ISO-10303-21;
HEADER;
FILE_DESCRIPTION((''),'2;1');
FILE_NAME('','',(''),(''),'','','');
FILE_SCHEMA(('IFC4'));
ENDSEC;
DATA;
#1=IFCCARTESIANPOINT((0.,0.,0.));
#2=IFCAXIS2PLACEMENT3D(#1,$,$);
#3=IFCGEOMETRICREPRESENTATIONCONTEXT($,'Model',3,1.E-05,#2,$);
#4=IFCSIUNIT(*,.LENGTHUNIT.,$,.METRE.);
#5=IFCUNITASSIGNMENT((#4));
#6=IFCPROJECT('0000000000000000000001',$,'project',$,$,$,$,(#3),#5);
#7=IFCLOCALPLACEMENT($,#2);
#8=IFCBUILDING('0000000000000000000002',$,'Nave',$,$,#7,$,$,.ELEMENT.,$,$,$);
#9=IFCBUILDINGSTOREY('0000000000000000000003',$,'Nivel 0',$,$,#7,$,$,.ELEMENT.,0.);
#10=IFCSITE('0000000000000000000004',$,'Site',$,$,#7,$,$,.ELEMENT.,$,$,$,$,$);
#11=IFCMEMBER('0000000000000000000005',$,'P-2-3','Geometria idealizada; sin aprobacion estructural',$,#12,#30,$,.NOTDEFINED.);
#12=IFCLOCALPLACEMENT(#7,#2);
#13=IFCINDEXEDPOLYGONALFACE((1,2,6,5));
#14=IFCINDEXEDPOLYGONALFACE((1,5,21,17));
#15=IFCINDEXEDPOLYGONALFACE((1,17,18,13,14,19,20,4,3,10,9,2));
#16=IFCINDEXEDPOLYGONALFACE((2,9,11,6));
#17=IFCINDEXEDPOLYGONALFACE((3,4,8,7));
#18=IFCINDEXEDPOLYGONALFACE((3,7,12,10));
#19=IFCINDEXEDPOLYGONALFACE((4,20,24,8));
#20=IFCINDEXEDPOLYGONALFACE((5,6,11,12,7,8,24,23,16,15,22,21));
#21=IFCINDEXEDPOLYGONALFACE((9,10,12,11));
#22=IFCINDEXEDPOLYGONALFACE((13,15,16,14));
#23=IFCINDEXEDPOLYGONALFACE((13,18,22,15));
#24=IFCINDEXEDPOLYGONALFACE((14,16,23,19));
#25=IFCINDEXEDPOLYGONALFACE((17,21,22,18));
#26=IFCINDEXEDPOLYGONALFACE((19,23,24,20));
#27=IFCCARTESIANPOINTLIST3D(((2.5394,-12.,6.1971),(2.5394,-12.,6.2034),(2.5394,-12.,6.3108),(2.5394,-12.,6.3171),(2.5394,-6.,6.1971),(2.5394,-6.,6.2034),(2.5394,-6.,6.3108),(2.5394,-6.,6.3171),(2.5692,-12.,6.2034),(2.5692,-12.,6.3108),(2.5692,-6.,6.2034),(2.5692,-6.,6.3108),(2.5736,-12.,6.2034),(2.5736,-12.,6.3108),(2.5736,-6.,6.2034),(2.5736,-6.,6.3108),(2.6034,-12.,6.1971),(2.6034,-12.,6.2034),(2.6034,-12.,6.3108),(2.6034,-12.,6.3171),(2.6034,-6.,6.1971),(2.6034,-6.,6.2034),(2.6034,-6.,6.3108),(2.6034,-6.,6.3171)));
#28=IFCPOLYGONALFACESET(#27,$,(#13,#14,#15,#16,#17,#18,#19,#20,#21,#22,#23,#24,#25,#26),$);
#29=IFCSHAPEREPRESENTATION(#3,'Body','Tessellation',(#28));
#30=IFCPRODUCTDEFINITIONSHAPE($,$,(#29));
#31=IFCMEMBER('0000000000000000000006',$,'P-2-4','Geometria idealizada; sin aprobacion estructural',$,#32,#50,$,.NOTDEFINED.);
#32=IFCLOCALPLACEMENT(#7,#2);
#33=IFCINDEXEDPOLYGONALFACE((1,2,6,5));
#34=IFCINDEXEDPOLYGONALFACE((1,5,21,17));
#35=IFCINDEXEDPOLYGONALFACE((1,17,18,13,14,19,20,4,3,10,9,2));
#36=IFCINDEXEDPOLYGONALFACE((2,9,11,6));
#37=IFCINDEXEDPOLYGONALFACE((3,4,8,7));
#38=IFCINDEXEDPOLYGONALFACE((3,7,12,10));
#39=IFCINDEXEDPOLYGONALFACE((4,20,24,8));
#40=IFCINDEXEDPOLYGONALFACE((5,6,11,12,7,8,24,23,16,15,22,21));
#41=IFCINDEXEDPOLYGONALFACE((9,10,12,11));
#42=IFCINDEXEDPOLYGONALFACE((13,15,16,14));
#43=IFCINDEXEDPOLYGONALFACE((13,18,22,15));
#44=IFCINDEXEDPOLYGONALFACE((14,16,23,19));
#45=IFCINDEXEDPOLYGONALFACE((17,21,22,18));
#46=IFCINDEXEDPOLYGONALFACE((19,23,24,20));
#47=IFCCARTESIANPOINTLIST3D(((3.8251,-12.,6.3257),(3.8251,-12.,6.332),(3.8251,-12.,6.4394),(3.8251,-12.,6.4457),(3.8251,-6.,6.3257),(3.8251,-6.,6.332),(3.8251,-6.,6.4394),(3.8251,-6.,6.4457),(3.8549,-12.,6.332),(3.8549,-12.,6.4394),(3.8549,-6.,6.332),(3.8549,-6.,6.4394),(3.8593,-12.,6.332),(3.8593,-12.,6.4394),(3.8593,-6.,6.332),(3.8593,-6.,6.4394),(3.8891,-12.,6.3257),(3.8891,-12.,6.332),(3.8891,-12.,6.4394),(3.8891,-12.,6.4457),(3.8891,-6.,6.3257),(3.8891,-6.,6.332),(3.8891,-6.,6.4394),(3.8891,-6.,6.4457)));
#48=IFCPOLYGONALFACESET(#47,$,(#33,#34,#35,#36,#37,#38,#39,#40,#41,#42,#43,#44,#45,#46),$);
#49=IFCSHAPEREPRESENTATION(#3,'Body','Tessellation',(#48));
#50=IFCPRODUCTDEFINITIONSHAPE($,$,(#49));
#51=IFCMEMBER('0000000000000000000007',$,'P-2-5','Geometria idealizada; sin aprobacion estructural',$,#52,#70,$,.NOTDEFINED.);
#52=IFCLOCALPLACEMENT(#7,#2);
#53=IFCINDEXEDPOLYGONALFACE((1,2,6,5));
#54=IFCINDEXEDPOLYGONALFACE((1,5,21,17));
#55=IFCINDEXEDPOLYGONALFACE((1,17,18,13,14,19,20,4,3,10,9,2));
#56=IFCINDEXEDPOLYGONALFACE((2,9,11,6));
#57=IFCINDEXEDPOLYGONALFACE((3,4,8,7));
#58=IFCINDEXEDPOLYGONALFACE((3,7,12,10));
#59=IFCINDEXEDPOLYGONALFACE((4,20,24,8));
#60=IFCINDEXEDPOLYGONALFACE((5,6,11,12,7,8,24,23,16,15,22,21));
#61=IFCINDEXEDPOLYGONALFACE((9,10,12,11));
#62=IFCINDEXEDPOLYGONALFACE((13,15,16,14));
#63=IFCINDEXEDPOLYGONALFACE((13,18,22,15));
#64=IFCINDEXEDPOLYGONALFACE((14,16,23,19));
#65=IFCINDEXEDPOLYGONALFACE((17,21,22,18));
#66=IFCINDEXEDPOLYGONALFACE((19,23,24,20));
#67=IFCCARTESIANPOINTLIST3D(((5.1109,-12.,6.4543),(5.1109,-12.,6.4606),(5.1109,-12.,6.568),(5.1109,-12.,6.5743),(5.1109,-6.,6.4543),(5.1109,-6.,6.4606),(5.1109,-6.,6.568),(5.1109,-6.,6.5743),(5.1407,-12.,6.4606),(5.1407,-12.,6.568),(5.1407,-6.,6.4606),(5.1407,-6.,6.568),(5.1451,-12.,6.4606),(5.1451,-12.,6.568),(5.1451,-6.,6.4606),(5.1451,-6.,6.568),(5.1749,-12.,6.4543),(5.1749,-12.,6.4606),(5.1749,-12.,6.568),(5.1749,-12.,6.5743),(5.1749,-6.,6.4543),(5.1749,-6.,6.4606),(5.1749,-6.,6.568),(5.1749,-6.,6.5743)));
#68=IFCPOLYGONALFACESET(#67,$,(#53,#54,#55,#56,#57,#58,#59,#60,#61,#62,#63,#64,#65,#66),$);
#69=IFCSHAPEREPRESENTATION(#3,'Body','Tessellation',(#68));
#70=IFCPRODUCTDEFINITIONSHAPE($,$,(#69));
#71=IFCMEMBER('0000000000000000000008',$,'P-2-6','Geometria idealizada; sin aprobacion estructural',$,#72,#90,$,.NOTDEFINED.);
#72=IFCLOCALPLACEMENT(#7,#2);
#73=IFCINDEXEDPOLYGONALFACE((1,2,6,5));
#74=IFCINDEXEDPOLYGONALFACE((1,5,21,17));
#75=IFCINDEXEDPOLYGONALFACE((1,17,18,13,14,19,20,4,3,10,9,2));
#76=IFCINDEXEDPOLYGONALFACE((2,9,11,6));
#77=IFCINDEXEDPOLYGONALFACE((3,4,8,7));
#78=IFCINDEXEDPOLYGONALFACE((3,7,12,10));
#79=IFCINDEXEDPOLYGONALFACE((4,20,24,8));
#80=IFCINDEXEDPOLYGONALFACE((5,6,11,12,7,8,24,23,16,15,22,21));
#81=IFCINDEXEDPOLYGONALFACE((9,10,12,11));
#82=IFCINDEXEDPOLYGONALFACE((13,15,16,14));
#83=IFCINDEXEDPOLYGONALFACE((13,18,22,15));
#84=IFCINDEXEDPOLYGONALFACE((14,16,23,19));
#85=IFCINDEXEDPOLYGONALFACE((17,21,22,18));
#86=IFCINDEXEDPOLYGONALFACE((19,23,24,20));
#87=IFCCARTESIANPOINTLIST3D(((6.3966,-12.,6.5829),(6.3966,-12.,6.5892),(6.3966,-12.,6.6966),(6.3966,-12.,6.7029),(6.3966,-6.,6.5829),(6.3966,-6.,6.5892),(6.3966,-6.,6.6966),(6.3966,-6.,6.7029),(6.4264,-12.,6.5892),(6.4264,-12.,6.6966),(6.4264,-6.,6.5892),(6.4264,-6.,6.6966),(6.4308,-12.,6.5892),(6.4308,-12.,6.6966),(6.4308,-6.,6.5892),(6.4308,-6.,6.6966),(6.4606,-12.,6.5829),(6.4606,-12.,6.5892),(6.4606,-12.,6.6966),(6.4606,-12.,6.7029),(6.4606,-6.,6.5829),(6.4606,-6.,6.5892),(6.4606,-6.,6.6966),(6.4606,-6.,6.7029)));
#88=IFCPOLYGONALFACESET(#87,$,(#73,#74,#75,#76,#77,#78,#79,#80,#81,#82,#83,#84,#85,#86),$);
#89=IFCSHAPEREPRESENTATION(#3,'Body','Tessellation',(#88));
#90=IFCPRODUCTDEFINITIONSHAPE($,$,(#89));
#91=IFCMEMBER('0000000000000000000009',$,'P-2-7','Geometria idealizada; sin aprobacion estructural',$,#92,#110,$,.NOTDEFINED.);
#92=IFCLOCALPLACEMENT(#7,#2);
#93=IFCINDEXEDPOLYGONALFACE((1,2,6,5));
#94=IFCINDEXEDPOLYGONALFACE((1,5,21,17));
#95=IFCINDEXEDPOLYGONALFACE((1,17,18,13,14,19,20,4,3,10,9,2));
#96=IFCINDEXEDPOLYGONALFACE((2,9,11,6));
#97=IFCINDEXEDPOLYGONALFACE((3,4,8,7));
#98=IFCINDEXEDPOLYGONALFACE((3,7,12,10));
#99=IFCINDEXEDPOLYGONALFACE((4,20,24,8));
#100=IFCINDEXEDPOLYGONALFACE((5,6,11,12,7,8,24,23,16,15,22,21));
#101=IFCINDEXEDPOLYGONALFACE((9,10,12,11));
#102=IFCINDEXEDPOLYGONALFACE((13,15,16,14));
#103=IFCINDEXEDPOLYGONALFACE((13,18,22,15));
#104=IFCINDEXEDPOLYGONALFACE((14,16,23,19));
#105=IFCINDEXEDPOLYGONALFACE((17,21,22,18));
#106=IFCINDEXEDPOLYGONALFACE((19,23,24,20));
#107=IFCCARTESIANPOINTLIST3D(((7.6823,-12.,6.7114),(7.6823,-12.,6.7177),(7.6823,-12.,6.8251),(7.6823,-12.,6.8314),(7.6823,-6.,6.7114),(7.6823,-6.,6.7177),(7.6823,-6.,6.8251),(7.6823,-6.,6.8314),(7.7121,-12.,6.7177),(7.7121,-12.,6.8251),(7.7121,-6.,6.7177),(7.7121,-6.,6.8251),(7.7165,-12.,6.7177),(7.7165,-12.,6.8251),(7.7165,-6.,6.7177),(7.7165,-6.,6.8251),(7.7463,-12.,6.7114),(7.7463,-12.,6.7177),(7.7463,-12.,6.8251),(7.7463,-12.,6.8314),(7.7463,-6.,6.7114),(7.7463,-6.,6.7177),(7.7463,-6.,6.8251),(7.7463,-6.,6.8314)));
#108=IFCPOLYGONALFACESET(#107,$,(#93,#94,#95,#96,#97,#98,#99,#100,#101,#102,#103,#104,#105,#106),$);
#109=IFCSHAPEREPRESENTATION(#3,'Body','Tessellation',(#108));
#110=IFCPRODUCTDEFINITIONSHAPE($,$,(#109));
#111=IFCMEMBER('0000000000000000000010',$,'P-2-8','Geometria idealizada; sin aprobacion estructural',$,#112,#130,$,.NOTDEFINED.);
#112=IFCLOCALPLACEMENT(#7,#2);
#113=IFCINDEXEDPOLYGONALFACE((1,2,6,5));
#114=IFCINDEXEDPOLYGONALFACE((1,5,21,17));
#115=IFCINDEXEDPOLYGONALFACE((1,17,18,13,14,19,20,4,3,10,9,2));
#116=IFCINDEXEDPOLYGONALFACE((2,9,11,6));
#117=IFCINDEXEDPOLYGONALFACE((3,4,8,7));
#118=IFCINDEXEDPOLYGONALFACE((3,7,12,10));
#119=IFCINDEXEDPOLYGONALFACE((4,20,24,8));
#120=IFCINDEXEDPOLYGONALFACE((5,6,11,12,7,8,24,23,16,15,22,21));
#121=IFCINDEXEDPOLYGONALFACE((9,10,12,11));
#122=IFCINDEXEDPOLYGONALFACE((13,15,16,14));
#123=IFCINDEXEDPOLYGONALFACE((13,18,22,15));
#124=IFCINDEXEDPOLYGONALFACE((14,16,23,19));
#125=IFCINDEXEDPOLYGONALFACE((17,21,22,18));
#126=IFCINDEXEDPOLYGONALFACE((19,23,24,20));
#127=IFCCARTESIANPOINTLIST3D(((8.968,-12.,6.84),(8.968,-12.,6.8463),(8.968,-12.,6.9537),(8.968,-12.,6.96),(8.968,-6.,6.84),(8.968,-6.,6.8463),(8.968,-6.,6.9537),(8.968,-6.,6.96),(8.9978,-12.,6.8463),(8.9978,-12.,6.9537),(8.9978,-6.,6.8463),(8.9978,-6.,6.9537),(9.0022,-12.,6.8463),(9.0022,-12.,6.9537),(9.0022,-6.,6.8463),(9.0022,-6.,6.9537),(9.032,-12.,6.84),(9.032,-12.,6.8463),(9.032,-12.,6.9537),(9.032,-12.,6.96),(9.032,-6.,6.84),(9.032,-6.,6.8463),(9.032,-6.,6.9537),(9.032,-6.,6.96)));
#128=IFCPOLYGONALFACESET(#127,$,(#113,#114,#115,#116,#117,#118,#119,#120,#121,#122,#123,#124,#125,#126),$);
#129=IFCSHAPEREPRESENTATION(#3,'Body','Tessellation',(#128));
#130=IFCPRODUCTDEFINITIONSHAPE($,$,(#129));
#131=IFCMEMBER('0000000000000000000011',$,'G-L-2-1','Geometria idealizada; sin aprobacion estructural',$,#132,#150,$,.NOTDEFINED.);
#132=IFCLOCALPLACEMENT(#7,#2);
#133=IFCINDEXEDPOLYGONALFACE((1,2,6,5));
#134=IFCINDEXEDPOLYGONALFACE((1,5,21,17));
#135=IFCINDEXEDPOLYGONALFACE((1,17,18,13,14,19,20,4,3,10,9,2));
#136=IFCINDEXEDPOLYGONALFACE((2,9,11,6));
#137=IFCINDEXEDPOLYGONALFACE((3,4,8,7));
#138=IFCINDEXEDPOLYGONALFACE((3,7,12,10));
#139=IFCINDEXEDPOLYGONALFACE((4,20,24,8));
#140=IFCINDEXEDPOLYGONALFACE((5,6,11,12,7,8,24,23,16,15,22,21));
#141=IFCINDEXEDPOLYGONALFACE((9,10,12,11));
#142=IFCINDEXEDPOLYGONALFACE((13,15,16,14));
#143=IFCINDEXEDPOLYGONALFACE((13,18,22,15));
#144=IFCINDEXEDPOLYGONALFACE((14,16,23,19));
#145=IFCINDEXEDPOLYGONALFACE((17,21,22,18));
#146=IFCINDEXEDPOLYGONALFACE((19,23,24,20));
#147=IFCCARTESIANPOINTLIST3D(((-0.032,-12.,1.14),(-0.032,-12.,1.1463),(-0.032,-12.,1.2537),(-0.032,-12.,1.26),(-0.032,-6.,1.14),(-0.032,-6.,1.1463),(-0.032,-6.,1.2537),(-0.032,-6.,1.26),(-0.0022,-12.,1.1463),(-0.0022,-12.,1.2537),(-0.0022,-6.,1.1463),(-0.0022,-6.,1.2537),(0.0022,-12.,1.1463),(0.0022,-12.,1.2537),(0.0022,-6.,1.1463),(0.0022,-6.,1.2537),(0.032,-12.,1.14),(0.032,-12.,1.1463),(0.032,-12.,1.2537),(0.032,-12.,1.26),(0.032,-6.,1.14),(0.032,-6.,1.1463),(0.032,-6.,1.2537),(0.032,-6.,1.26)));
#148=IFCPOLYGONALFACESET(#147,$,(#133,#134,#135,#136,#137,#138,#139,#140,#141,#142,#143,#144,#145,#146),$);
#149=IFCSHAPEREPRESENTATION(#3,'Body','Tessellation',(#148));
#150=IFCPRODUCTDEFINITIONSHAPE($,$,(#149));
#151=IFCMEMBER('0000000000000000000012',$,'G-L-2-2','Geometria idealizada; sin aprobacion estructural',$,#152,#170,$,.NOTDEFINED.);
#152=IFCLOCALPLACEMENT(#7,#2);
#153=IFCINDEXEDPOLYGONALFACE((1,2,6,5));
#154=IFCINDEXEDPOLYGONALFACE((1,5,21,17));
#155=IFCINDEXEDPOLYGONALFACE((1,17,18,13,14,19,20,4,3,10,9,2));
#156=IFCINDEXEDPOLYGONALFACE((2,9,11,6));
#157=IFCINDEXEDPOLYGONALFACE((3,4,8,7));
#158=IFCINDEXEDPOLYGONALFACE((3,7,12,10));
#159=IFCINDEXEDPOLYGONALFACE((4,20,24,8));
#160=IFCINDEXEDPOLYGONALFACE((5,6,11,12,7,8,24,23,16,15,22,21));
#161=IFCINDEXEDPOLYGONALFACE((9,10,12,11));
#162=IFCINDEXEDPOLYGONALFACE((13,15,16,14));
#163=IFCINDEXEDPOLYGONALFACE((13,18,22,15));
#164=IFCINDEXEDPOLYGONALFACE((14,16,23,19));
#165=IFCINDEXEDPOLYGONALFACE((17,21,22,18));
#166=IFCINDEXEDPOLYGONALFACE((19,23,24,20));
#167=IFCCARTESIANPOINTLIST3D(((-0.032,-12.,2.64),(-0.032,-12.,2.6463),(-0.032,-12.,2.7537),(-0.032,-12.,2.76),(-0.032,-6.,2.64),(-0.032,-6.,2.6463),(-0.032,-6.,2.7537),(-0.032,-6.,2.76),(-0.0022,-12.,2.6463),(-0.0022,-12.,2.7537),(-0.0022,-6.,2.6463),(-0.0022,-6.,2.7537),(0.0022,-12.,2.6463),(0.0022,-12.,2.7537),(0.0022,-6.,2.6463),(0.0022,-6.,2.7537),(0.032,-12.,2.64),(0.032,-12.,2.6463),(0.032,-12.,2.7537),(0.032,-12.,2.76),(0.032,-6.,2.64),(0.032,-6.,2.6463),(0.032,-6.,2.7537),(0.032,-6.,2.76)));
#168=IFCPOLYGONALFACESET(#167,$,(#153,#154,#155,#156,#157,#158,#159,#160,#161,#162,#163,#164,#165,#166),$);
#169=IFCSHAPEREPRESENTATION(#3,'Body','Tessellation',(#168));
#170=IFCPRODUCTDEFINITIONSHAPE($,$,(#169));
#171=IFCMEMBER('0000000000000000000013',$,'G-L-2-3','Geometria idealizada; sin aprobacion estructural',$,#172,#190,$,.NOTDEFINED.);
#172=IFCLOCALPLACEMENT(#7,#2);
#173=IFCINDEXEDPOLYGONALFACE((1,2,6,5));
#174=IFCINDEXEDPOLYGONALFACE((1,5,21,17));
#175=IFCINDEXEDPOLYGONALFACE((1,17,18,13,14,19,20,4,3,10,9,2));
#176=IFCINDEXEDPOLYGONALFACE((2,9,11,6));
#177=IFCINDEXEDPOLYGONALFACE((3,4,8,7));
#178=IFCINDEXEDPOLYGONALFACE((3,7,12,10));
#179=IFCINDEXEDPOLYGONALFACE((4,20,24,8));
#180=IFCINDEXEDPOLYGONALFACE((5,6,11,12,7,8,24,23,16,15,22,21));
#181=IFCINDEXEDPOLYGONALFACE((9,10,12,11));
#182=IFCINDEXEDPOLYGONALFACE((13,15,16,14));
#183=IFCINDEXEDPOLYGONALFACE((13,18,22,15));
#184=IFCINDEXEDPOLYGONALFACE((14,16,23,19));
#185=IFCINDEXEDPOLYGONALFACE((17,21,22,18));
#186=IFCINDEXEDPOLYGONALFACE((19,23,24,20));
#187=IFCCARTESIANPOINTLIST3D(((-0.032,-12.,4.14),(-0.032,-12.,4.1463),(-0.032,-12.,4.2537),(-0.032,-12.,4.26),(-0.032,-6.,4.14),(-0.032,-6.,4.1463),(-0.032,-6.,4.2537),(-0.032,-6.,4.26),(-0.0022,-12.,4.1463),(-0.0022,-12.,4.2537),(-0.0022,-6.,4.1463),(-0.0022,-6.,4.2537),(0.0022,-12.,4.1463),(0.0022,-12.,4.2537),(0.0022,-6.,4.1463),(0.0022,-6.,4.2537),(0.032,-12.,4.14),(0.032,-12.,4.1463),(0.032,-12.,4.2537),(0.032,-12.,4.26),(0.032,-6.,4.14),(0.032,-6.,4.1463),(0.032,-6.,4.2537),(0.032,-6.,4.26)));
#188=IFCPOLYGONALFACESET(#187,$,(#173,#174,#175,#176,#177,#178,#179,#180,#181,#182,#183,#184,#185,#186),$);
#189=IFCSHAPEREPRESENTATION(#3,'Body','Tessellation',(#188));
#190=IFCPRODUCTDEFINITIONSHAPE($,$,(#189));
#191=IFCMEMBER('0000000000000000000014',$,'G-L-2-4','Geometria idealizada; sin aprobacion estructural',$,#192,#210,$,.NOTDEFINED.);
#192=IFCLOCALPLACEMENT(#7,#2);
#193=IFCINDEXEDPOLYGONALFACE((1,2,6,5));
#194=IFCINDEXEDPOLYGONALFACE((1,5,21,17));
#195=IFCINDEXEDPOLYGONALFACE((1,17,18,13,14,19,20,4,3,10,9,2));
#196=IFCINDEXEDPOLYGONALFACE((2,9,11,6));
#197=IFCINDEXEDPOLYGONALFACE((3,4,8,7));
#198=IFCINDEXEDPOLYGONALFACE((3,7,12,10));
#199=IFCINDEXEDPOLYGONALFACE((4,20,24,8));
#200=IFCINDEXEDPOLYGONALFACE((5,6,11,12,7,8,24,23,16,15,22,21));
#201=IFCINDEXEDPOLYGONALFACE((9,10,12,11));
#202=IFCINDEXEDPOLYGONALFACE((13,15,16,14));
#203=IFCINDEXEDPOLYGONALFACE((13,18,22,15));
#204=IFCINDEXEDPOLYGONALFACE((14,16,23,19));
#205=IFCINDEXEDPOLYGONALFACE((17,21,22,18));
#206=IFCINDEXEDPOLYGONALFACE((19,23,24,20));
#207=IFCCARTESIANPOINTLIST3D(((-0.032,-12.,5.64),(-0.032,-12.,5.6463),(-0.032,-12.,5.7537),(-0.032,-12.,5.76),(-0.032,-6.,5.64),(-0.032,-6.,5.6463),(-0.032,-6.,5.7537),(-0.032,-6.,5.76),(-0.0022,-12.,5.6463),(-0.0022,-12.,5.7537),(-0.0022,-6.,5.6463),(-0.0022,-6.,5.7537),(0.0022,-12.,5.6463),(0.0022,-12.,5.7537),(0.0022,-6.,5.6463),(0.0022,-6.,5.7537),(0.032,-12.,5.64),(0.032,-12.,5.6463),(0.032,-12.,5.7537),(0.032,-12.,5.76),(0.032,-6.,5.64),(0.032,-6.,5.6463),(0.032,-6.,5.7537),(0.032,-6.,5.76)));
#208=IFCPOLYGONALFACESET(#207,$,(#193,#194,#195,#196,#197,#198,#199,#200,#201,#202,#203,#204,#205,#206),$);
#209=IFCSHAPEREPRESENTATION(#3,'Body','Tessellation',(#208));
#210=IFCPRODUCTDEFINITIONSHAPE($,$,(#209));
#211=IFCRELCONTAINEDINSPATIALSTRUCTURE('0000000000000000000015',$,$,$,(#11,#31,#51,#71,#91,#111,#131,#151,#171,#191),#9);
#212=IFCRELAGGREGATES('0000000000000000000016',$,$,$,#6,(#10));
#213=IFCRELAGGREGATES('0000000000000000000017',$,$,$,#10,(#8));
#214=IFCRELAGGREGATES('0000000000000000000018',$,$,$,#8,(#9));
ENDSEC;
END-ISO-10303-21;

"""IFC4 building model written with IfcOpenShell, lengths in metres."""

from ifc_helpers import new_model, si_unit, frame, origin, place, context, project, spatial, polyline, outline, extrude, element, save


model = new_model("IFC4")

# Units and contexts
model_context = context("Model", 3, precision=1e-05, world=origin())
ifc_project = project(units=[si_unit("LENGTHUNIT", "METRE")], contexts=[model_context])

# Site, building, storey
placement = place(None, origin())
site = spatial("IfcSite", under=ifc_project, at=placement, Name="Site", CompositionType="ELEMENT")
building = spatial("IfcBuilding", under=site, at=placement, Name="Nave", CompositionType="ELEMENT")
storey = spatial("IfcBuildingStorey", under=building, at=placement, Name="Nivel 0", CompositionType="ELEMENT", Elevation=0.0)

# Members
for number, where, z_axis, x_axis, name in (
    (1, (2.5714, -6.0, 6.2571), (0.0, -1.0, 0.0), (1.0, 0.0, 0.0), "P-2-3"),
    (2, (3.8571, -6.0, 6.3857), (0.0, -1.0, 0.0), (1.0, 0.0, 0.0), "P-2-4"),
    (3, (5.1429, -6.0, 6.5143), (0.0, -1.0, 0.0), (1.0, 0.0, 0.0), "P-2-5"),
    (4, (6.4286, -6.0, 6.6429), (0.0, -1.0, 0.0), (1.0, 0.0, 0.0), "P-2-6"),
    (5, (7.7143, -6.0, 6.7714), (0.0, -1.0, 0.0), (1.0, 0.0, 0.0), "P-2-7"),
    (6, (9.0, -6.0, 6.9), (0.0, -1.0, 0.0), (1.0, 0.0, 0.0), "P-2-8"),
    (7, (0.0, -6.0, 1.2), (0.0, -1.0, 0.0), (1.0, 0.0, 0.0), "G-L-2-1"),
    (8, (0.0, -6.0, 2.7), (0.0, -1.0, 0.0), (1.0, 0.0, 0.0), "G-L-2-2"),
    (9, (0.0, -6.0, 4.2), (0.0, -1.0, 0.0), (1.0, 0.0, 0.0), "G-L-2-3"),
    (10, (0.0, -6.0, 5.7), (0.0, -1.0, 0.0), (1.0, 0.0, 0.0), "G-L-2-4"),
):
    element("IfcMember", number, at=place(placement, frame(where, z_axis=z_axis, x_axis=x_axis)), inside=storey, Name=name, Description="Geometria idealizada; sin aprobacion estructural", PredefinedType="NOTDEFINED", context=model_context, shape_type="SweptSolid", body=[
        extrude(outline(polyline([(-0.032, -0.06), (0.032, -0.06), (0.032, -0.0537), (0.0022, -0.0537), (0.0022, 0.0537), (0.032, 0.0537), (0.032, 0.06), (-0.032, 0.06), (-0.032, 0.0537), (-0.0022, 0.0537), (-0.0022, -0.0537), (-0.032, -0.0537), (-0.032, -0.06)])), origin(), (0.0, 0.0, 1.0), 6.0),
    ])

save(model, "model.ifc")
